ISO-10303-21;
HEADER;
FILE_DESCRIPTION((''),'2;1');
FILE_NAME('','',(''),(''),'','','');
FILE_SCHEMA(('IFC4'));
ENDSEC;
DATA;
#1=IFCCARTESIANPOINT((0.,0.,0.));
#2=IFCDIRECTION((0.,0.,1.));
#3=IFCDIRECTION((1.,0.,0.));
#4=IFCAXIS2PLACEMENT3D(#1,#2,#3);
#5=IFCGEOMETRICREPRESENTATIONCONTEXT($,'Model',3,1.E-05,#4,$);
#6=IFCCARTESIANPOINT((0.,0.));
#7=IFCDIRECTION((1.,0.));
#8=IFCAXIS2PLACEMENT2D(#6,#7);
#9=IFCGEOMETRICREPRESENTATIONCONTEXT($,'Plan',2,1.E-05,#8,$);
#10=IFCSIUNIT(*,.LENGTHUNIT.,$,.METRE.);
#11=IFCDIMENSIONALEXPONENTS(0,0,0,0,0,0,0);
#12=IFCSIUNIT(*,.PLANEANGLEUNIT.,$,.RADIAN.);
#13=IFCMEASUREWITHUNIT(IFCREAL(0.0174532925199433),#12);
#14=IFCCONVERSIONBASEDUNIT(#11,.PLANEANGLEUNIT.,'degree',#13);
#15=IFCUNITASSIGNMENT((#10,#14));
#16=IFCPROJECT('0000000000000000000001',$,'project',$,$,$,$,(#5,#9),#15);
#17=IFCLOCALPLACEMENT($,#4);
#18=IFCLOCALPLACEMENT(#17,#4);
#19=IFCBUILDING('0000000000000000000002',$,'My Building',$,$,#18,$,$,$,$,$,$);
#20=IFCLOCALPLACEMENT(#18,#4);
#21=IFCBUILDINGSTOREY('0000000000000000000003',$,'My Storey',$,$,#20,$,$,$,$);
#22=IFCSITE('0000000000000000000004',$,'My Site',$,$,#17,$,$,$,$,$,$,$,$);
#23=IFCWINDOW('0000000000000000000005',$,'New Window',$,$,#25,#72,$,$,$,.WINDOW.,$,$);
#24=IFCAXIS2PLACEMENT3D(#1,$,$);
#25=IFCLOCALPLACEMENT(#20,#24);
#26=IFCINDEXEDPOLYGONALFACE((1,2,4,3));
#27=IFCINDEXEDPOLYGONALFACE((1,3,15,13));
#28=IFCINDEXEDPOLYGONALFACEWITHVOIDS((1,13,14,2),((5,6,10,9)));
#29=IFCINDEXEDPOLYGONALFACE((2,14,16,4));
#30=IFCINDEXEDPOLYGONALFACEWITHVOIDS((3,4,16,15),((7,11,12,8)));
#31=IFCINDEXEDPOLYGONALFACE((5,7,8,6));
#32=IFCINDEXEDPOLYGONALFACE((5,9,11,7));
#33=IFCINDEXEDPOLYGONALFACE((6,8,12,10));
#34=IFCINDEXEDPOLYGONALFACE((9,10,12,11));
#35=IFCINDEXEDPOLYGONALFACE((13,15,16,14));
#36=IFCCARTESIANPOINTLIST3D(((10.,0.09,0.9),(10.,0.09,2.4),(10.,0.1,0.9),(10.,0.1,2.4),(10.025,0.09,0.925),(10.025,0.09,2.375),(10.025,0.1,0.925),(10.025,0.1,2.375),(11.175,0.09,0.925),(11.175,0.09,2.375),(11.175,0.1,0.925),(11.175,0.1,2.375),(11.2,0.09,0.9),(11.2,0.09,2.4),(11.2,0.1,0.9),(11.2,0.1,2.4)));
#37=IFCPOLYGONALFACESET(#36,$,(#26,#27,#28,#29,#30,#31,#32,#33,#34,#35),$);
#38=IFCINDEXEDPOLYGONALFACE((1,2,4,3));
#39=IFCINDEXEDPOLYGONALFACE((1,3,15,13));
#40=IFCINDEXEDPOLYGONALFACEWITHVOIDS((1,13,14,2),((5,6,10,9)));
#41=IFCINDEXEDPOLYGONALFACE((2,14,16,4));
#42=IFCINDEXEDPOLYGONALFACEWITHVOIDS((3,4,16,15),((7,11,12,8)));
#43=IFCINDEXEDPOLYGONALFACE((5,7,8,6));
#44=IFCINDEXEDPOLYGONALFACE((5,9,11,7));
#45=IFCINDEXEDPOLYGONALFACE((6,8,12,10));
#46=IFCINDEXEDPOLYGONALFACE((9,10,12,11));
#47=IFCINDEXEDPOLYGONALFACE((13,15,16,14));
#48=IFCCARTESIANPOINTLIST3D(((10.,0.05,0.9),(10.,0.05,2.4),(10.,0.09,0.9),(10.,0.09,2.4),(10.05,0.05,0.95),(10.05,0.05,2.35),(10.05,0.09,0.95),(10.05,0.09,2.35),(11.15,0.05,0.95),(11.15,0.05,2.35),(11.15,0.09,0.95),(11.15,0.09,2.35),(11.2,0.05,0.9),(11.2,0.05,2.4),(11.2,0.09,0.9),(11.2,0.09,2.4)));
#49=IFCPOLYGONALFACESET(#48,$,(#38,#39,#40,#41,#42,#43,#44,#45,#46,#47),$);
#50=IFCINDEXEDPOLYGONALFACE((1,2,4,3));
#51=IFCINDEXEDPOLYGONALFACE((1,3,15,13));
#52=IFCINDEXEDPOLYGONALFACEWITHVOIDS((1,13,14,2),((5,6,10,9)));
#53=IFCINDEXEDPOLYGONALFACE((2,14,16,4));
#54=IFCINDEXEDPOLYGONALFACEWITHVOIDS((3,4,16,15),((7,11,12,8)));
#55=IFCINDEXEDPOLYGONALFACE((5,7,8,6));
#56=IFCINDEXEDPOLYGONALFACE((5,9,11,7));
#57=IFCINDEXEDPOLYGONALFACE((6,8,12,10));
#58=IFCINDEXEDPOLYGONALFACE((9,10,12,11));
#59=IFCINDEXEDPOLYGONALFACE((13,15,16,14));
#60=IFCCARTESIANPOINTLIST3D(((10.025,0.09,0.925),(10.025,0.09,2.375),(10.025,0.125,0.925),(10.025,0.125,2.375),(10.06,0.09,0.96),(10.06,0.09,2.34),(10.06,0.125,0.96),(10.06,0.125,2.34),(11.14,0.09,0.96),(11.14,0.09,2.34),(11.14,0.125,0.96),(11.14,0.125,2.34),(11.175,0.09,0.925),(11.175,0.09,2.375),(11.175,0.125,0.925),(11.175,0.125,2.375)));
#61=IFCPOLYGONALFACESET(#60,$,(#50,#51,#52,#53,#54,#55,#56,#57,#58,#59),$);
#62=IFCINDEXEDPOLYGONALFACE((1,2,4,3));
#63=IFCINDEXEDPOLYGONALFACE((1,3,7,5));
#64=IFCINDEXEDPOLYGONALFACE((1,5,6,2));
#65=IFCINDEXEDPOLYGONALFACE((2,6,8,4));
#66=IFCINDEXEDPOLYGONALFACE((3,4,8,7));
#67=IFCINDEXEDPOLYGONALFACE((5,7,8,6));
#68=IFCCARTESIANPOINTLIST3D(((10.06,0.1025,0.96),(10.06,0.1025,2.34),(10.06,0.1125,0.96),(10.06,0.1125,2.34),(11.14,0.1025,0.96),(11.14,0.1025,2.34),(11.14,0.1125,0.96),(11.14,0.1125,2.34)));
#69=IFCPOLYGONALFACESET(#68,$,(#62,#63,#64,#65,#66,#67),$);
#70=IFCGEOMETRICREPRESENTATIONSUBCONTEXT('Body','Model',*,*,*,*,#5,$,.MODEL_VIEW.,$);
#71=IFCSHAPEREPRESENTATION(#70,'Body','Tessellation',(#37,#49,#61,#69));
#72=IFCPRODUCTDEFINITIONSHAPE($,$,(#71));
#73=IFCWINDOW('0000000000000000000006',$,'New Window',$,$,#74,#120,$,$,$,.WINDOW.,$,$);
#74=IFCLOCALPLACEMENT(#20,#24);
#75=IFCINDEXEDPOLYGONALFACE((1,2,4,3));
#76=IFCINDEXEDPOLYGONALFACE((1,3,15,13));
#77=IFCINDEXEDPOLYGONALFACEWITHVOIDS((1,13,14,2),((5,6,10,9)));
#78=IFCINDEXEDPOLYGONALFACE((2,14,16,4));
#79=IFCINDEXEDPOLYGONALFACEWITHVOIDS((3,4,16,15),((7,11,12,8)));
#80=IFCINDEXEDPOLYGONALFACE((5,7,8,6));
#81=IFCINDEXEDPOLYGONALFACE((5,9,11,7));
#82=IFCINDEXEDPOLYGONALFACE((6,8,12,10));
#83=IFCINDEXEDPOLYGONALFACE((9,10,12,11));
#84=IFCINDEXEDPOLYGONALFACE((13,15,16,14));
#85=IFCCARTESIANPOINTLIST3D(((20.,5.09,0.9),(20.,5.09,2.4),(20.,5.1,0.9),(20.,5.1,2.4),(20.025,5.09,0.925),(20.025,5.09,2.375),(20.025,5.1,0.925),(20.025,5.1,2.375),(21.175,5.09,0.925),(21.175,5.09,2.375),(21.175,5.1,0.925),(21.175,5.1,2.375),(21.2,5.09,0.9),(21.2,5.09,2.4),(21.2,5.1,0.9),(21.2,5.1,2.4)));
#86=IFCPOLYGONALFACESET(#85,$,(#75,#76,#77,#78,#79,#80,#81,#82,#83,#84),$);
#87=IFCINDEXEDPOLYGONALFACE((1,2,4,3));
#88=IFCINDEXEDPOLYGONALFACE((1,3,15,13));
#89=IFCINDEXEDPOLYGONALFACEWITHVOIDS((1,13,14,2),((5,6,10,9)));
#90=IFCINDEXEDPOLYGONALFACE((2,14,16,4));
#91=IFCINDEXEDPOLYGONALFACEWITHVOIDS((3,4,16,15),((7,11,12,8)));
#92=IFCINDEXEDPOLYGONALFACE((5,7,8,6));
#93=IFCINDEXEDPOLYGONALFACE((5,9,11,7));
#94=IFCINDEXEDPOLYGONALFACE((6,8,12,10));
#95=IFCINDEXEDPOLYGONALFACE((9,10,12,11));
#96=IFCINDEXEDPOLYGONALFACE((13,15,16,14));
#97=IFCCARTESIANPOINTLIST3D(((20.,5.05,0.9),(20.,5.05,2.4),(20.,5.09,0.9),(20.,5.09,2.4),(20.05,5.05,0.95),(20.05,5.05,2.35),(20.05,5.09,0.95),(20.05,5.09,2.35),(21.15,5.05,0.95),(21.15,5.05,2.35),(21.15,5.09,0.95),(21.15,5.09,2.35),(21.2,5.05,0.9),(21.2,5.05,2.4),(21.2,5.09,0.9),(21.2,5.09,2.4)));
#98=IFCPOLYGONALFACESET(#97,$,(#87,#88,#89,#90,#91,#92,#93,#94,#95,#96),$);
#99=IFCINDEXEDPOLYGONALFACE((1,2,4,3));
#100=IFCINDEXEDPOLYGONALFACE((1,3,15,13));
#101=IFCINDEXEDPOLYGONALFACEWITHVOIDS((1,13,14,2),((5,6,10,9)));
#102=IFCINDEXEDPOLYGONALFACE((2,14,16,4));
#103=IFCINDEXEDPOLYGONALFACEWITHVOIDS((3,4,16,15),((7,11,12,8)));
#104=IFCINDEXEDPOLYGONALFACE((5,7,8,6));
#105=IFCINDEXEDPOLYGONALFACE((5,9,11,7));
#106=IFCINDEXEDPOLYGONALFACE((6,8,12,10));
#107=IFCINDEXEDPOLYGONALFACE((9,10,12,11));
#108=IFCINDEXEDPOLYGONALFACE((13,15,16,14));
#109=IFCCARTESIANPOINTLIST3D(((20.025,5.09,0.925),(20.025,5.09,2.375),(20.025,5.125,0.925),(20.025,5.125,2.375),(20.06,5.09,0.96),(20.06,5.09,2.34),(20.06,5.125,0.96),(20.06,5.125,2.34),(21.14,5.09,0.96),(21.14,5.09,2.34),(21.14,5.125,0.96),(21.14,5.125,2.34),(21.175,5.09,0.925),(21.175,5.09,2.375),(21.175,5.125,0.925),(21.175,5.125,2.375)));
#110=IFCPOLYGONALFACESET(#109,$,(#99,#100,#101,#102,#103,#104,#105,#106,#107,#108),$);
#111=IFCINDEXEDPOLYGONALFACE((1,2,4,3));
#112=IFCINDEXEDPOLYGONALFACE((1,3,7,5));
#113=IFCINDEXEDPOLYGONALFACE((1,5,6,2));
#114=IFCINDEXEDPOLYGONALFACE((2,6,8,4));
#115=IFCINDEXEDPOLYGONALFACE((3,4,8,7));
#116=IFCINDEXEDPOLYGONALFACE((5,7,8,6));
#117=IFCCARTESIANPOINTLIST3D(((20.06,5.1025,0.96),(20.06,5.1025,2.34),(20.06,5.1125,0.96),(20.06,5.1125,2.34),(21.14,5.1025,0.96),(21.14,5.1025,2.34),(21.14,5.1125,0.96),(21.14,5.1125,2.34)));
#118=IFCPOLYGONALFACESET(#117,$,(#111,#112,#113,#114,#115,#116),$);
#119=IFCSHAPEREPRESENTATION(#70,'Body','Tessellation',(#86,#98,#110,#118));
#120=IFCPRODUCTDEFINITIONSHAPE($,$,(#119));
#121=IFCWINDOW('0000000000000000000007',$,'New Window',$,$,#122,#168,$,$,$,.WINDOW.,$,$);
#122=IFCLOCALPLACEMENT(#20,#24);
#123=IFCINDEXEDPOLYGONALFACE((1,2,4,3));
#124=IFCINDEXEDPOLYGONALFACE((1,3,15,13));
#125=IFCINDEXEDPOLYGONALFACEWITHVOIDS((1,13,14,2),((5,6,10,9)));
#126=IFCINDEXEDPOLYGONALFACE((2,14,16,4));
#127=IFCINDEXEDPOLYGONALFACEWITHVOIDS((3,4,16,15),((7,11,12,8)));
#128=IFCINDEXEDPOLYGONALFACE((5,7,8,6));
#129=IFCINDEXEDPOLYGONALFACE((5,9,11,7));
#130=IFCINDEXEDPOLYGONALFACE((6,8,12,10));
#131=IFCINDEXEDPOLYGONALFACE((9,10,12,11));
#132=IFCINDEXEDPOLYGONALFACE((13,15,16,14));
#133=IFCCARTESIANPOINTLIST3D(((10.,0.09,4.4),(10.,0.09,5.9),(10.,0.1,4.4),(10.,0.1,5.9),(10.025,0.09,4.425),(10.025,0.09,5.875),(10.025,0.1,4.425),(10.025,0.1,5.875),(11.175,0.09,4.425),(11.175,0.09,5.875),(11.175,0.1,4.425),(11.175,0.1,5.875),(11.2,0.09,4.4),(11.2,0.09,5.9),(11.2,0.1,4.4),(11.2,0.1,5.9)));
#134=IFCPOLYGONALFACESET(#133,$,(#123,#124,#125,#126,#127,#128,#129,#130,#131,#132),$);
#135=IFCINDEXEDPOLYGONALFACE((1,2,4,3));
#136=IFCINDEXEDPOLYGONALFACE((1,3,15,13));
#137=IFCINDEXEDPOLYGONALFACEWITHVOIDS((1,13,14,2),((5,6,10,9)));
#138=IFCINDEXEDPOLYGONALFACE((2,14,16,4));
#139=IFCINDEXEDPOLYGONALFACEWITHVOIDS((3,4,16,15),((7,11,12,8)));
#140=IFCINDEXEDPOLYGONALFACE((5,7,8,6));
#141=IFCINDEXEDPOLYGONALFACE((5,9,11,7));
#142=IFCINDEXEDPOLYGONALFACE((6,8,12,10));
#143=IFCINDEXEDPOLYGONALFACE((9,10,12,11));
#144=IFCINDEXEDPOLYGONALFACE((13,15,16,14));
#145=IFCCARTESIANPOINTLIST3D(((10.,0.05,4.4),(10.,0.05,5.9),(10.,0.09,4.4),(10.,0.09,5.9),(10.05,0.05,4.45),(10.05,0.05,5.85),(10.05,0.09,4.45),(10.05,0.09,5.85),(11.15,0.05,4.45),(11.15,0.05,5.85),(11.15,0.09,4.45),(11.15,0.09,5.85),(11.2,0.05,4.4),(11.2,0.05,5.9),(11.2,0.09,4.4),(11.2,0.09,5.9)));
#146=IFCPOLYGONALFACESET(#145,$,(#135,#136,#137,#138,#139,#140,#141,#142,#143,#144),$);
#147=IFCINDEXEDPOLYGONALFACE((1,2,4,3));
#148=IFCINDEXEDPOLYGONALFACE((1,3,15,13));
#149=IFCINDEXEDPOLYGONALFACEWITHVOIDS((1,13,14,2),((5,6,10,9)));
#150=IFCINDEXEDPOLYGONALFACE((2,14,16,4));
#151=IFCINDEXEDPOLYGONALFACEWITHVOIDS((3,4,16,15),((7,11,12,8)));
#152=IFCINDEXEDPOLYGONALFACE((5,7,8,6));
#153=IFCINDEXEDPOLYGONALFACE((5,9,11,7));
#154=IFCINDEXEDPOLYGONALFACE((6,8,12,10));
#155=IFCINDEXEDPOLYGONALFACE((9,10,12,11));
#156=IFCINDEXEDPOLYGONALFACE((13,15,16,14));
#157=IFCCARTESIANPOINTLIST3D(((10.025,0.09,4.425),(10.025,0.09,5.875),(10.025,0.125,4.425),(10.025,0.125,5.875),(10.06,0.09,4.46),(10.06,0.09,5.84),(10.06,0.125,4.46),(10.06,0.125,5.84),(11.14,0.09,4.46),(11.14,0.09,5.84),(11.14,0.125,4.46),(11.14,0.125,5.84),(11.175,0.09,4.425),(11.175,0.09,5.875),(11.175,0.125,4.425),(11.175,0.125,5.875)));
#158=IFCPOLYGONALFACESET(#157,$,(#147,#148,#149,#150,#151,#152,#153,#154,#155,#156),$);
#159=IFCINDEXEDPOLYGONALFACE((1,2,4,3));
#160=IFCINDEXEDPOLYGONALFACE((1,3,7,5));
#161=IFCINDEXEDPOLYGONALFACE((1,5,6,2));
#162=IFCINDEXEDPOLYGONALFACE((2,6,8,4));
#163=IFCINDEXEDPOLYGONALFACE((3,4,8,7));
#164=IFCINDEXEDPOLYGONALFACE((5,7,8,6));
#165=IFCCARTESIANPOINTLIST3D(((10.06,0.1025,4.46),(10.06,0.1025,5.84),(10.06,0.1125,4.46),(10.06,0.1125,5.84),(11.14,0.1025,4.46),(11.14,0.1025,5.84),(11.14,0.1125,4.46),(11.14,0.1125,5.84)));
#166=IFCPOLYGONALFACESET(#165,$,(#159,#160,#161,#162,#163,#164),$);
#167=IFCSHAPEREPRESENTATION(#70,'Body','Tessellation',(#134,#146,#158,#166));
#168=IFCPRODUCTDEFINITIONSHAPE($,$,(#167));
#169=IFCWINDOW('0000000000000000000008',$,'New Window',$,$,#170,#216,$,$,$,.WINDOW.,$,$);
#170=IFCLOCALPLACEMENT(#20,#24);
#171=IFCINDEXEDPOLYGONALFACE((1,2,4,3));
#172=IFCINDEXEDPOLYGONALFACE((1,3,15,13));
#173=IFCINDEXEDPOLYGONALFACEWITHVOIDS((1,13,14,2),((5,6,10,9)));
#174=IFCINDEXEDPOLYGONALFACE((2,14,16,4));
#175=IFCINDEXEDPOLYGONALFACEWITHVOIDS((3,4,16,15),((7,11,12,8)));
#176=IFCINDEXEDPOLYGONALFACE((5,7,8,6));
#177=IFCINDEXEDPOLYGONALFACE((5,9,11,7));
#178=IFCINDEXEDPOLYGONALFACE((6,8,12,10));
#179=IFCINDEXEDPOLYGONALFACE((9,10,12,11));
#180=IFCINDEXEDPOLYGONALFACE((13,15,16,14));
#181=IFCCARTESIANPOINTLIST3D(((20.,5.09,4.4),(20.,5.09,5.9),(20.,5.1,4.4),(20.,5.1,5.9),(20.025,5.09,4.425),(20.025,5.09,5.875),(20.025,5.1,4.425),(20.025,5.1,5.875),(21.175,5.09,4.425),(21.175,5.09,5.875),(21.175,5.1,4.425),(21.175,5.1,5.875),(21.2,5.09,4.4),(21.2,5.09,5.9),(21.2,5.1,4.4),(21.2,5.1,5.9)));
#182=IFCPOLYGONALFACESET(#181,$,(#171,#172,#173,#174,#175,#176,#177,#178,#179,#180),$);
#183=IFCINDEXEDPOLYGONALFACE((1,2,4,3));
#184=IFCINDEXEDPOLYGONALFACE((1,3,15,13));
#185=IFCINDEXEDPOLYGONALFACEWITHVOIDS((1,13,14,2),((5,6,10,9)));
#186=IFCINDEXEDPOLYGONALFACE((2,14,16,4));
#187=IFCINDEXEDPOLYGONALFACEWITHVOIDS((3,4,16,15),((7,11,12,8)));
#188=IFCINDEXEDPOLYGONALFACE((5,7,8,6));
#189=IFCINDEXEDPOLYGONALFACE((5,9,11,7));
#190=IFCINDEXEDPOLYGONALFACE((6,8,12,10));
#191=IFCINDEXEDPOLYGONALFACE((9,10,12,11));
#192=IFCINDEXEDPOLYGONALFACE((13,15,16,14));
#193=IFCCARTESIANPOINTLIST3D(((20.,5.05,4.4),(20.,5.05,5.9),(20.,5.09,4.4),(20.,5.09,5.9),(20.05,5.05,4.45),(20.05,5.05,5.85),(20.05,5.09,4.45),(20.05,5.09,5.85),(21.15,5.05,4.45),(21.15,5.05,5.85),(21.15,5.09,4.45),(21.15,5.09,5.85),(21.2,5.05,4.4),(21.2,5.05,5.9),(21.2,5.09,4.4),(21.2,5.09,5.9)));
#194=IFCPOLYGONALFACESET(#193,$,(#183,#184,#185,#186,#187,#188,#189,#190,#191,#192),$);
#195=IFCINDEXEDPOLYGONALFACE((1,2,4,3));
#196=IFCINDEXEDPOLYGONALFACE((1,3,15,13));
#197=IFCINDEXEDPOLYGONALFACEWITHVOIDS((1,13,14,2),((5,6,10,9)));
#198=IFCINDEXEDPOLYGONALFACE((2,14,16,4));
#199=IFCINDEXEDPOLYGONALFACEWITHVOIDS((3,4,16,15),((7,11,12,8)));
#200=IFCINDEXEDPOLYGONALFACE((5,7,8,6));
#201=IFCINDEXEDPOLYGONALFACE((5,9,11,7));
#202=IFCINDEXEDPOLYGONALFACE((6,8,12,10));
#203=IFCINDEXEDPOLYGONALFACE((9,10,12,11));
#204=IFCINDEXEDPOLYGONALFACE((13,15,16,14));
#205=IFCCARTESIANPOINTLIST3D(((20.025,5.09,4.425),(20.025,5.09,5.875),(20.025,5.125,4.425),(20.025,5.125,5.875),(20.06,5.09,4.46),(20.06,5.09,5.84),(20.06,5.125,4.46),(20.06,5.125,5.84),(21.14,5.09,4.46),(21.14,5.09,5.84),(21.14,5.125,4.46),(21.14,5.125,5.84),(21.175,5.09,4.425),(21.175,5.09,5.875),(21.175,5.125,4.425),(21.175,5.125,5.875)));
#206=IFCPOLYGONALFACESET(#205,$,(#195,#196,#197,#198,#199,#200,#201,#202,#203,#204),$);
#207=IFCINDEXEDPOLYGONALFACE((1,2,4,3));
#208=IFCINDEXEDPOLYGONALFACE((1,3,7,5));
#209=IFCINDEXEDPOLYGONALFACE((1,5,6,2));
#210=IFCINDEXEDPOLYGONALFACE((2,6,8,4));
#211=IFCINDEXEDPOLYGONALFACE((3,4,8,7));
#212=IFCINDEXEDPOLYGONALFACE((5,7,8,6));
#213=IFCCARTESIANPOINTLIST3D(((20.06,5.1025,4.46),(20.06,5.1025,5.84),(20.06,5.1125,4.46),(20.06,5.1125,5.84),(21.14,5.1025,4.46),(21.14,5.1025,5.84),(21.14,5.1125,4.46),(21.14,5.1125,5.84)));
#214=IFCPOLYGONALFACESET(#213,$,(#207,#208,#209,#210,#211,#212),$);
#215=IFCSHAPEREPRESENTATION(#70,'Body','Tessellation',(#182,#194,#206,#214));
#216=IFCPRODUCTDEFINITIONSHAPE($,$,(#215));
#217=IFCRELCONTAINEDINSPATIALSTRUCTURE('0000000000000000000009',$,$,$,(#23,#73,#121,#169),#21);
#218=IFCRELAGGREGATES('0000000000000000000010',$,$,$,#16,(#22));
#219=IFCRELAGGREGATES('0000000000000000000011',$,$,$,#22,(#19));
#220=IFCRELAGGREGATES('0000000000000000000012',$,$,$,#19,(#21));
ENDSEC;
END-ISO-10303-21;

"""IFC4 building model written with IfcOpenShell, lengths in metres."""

from ifc_helpers import new_model, entity, si_unit, converted_unit, frame, origin_with_axes, origin_2d_with_axis, place, context, subcontext, project, spatial, line, indexed_curve, outline, extrude, element, save


model = new_model("IFC4")

# Units and contexts
model_context = context("Model", 3, precision=1e-05, world=origin_with_axes())
plan_context = context("Plan", 2, precision=1e-05, world=origin_2d_with_axis())
body_context = subcontext(model_context, "Body", "Model", "MODEL_VIEW")
ifc_project = project(units=[si_unit("LENGTHUNIT", "METRE"), converted_unit("PLANEANGLEUNIT", "degree", entity("IfcReal", 0.0174532925199433), si_unit("PLANEANGLEUNIT", "RADIAN"), dimensions=[0, 0, 0, 0, 0, 0, 0])], contexts=[model_context, plan_context])

# Site, building, storey
site_placement = place(None, origin_with_axes())
site = spatial("IfcSite", under=ifc_project, at=site_placement, Name="My Site")
building_placement = place(site_placement, origin_with_axes())
building = spatial("IfcBuilding", under=site, at=building_placement, Name="My Building")
storey_placement = place(building_placement, origin_with_axes())
storey = spatial("IfcBuildingStorey", under=building, at=storey_placement, Name="My Storey")

# Windows
for number, where, z_axis, x_axis, name in (
    (1, (10.0, 0.0, 0.9), (0.0, 0.0, 1.0), (1.0, 0.0, 0.0), "New Window"),
    (2, (20.0, 5.0, 0.9), (0.0, 0.0, 1.0), (1.0, 0.0, 0.0), "New Window"),
    (3, (10.0, 0.0, 4.4), (0.0, 0.0, 1.0), (1.0, 0.0, 0.0), "New Window"),
    (4, (20.0, 5.0, 4.4), (0.0, 0.0, 1.0), (1.0, 0.0, 0.0), "New Window"),
):
    element("IfcWindow", number, at=place(storey_placement, frame(where, z_axis=z_axis, x_axis=x_axis)), inside=storey, Name=name, PredefinedType="WINDOW", context=body_context, shape_type="SweptSolid", body=[
        extrude(outline(indexed_curve([(0.0, 0.0), (1.2, 0.0), (1.2, 1.5), (0.0, 1.5)], segments=[line(1, 2, 3, 4, 1)]), holes=[indexed_curve([(0.025, 0.025), (1.175, 0.025), (1.175, 1.475), (0.025, 1.475)], segments=[line(1, 2, 3, 4, 1)])]), frame((0.0, 0.09, 0.0), z_axis=(0.0, -1.0, 0.0), x_axis=(1.0, 0.0, 0.0)), (0.0, 0.0, -1.0), 0.01),
        extrude(outline(indexed_curve([(0.0, 0.0), (1.2, 0.0), (1.2, 1.5), (0.0, 1.5)], segments=[line(1, 2, 3, 4, 1)]), holes=[indexed_curve([(0.05, 0.05), (1.15, 0.05), (1.15, 1.45), (0.05, 1.45)], segments=[line(1, 2, 3, 4, 1)])]), frame((0.0, 0.05, 0.0), z_axis=(0.0, -1.0, 0.0), x_axis=(1.0, 0.0, 0.0)), (0.0, 0.0, -1.0), 0.04),
        extrude(outline(indexed_curve([(0.0, 0.0), (1.15, 0.0), (1.15, 1.45), (0.0, 1.45)], segments=[line(1, 2, 3, 4, 1)]), holes=[indexed_curve([(0.035, 0.035), (1.115, 0.035), (1.115, 1.415), (0.035, 1.415)], segments=[line(1, 2, 3, 4, 1)])]), frame((0.025, 0.09, 0.025), z_axis=(0.0, -1.0, 0.0), x_axis=(1.0, 0.0, 0.0)), (0.0, 0.0, -1.0), 0.035),
        extrude(outline(indexed_curve([(0.035, 0.035), (1.115, 0.035), (1.115, 1.415), (0.035, 1.415)], segments=[line(1, 2, 3, 4, 1)])), frame((0.025, 0.1025, 0.025), z_axis=(0.0, -1.0, 0.0), x_axis=(1.0, 0.0, 0.0)), (0.0, 0.0, -1.0), 0.01),
    ])

save(model, "model.ifc")
